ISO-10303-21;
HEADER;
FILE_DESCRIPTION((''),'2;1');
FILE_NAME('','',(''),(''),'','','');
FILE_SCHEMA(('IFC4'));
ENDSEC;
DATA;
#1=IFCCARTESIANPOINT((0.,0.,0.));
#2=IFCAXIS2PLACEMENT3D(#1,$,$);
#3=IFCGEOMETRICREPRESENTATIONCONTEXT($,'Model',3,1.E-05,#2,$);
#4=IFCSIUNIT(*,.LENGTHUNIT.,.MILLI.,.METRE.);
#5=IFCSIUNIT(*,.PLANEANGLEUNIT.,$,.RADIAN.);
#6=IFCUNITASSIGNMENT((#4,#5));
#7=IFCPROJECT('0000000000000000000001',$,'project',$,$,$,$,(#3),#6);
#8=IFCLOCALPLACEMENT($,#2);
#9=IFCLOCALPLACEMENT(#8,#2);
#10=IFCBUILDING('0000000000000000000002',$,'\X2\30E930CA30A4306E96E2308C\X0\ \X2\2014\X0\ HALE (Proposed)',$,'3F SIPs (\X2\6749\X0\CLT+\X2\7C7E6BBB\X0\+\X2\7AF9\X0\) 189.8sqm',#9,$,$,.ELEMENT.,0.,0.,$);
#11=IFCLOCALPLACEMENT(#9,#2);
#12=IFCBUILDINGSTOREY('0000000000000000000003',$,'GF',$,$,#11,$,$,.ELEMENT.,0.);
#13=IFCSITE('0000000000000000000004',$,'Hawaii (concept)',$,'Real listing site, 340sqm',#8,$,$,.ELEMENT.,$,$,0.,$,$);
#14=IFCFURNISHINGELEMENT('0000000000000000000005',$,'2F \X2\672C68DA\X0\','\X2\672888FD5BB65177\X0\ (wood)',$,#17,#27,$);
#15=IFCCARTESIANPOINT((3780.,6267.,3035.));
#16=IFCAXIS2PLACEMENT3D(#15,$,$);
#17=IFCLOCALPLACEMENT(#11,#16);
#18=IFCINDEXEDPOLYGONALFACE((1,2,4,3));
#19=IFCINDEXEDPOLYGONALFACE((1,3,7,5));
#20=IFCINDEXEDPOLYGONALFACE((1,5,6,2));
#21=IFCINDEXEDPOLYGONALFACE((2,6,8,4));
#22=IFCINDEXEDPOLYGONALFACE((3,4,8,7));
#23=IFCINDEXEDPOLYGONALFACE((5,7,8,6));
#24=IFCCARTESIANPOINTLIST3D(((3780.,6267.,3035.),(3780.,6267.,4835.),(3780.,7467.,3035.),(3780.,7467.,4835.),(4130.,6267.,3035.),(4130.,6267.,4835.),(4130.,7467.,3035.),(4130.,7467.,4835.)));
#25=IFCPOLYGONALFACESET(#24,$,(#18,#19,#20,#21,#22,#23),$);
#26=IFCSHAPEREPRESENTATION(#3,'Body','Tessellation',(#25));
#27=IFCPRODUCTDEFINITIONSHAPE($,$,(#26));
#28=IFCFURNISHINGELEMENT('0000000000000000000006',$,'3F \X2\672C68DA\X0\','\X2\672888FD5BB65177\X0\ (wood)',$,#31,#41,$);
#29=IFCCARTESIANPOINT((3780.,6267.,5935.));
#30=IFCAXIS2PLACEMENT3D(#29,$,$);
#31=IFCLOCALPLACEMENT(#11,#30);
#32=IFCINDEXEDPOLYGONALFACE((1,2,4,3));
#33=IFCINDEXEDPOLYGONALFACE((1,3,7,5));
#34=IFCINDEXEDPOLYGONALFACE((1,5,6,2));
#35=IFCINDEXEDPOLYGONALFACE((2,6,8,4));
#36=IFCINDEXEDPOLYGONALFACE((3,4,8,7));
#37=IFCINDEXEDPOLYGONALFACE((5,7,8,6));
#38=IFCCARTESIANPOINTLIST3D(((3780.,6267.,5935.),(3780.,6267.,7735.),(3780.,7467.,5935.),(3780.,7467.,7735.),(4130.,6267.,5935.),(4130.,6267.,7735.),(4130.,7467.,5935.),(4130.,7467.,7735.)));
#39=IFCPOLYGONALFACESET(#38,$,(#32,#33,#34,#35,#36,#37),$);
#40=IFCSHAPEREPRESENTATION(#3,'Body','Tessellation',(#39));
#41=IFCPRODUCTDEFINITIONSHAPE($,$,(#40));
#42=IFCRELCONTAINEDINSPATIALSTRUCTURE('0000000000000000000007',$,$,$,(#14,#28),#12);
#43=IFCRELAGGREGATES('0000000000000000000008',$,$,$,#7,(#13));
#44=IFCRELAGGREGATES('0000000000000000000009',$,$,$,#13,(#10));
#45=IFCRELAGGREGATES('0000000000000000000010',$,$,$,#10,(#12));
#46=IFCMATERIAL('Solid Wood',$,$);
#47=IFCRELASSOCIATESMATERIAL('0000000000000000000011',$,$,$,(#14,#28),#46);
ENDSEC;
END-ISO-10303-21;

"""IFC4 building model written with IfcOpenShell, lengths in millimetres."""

from ifc_helpers import new_model, si_unit, frame, frame_2d, origin, place, context, project, spatial, rectangle, extrude, material, element, save


model = new_model("IFC4")

# Units and contexts
model_context = context("Model", 3, precision=1e-05, world=origin())
ifc_project = project(units=[si_unit("LENGTHUNIT", "METRE", prefix="MILLI"), si_unit("PLANEANGLEUNIT", "RADIAN")], contexts=[model_context])

# Site, building, storey
site_placement = place(None, origin())
site = spatial("IfcSite", under=ifc_project, at=site_placement, Name="Hawaii (concept)", ObjectType="Real listing site, 340sqm", CompositionType="ELEMENT", RefElevation=0.0)
building_placement = place(site_placement, origin())
building = spatial("IfcBuilding", under=site, at=building_placement, Name="ラナイの離れ — HALE (Proposed)", ObjectType="3F SIPs (杉CLT+籾殻+竹) 189.8sqm", CompositionType="ELEMENT", ElevationOfRefHeight=0.0, ElevationOfTerrain=0.0)
storey_placement = place(building_placement, origin())
storey = spatial("IfcBuildingStorey", under=building, at=storey_placement, Name="GF", CompositionType="ELEMENT", Elevation=0.0)

# Shared definitions
ifc_material_1 = material(Name="Solid Wood")

# Furnishing elements
furnishing_1_placement = place(storey_placement, frame((3780.0, 6267.0, 3035.0)))
element("IfcFurnishingElement", 1, at=furnishing_1_placement, inside=storey, material=ifc_material_1, Name="2F 本棚", Description="木製家具 (wood)", context=model_context, shape_type="SweptSolid", body=[
    extrude(rectangle(XDim=350.0, YDim=1200.0, at=frame_2d((175.0, 600.0))), frame((3780.0, 6267.0, 3035.0)), (0.0, 0.0, 1.0), 1800.0),
])
furnishing_2_placement = place(storey_placement, frame((3780.0, 6267.0, 5935.0)))
element("IfcFurnishingElement", 2, at=furnishing_2_placement, inside=storey, material=ifc_material_1, Name="3F 本棚", Description="木製家具 (wood)", context=model_context, shape_type="SweptSolid", body=[
    extrude(rectangle(XDim=350.0, YDim=1200.0, at=frame_2d((175.0, 600.0))), frame((3780.0, 6267.0, 5935.0)), (0.0, 0.0, 1.0), 1800.0),
])

save(model, "model.ifc")
